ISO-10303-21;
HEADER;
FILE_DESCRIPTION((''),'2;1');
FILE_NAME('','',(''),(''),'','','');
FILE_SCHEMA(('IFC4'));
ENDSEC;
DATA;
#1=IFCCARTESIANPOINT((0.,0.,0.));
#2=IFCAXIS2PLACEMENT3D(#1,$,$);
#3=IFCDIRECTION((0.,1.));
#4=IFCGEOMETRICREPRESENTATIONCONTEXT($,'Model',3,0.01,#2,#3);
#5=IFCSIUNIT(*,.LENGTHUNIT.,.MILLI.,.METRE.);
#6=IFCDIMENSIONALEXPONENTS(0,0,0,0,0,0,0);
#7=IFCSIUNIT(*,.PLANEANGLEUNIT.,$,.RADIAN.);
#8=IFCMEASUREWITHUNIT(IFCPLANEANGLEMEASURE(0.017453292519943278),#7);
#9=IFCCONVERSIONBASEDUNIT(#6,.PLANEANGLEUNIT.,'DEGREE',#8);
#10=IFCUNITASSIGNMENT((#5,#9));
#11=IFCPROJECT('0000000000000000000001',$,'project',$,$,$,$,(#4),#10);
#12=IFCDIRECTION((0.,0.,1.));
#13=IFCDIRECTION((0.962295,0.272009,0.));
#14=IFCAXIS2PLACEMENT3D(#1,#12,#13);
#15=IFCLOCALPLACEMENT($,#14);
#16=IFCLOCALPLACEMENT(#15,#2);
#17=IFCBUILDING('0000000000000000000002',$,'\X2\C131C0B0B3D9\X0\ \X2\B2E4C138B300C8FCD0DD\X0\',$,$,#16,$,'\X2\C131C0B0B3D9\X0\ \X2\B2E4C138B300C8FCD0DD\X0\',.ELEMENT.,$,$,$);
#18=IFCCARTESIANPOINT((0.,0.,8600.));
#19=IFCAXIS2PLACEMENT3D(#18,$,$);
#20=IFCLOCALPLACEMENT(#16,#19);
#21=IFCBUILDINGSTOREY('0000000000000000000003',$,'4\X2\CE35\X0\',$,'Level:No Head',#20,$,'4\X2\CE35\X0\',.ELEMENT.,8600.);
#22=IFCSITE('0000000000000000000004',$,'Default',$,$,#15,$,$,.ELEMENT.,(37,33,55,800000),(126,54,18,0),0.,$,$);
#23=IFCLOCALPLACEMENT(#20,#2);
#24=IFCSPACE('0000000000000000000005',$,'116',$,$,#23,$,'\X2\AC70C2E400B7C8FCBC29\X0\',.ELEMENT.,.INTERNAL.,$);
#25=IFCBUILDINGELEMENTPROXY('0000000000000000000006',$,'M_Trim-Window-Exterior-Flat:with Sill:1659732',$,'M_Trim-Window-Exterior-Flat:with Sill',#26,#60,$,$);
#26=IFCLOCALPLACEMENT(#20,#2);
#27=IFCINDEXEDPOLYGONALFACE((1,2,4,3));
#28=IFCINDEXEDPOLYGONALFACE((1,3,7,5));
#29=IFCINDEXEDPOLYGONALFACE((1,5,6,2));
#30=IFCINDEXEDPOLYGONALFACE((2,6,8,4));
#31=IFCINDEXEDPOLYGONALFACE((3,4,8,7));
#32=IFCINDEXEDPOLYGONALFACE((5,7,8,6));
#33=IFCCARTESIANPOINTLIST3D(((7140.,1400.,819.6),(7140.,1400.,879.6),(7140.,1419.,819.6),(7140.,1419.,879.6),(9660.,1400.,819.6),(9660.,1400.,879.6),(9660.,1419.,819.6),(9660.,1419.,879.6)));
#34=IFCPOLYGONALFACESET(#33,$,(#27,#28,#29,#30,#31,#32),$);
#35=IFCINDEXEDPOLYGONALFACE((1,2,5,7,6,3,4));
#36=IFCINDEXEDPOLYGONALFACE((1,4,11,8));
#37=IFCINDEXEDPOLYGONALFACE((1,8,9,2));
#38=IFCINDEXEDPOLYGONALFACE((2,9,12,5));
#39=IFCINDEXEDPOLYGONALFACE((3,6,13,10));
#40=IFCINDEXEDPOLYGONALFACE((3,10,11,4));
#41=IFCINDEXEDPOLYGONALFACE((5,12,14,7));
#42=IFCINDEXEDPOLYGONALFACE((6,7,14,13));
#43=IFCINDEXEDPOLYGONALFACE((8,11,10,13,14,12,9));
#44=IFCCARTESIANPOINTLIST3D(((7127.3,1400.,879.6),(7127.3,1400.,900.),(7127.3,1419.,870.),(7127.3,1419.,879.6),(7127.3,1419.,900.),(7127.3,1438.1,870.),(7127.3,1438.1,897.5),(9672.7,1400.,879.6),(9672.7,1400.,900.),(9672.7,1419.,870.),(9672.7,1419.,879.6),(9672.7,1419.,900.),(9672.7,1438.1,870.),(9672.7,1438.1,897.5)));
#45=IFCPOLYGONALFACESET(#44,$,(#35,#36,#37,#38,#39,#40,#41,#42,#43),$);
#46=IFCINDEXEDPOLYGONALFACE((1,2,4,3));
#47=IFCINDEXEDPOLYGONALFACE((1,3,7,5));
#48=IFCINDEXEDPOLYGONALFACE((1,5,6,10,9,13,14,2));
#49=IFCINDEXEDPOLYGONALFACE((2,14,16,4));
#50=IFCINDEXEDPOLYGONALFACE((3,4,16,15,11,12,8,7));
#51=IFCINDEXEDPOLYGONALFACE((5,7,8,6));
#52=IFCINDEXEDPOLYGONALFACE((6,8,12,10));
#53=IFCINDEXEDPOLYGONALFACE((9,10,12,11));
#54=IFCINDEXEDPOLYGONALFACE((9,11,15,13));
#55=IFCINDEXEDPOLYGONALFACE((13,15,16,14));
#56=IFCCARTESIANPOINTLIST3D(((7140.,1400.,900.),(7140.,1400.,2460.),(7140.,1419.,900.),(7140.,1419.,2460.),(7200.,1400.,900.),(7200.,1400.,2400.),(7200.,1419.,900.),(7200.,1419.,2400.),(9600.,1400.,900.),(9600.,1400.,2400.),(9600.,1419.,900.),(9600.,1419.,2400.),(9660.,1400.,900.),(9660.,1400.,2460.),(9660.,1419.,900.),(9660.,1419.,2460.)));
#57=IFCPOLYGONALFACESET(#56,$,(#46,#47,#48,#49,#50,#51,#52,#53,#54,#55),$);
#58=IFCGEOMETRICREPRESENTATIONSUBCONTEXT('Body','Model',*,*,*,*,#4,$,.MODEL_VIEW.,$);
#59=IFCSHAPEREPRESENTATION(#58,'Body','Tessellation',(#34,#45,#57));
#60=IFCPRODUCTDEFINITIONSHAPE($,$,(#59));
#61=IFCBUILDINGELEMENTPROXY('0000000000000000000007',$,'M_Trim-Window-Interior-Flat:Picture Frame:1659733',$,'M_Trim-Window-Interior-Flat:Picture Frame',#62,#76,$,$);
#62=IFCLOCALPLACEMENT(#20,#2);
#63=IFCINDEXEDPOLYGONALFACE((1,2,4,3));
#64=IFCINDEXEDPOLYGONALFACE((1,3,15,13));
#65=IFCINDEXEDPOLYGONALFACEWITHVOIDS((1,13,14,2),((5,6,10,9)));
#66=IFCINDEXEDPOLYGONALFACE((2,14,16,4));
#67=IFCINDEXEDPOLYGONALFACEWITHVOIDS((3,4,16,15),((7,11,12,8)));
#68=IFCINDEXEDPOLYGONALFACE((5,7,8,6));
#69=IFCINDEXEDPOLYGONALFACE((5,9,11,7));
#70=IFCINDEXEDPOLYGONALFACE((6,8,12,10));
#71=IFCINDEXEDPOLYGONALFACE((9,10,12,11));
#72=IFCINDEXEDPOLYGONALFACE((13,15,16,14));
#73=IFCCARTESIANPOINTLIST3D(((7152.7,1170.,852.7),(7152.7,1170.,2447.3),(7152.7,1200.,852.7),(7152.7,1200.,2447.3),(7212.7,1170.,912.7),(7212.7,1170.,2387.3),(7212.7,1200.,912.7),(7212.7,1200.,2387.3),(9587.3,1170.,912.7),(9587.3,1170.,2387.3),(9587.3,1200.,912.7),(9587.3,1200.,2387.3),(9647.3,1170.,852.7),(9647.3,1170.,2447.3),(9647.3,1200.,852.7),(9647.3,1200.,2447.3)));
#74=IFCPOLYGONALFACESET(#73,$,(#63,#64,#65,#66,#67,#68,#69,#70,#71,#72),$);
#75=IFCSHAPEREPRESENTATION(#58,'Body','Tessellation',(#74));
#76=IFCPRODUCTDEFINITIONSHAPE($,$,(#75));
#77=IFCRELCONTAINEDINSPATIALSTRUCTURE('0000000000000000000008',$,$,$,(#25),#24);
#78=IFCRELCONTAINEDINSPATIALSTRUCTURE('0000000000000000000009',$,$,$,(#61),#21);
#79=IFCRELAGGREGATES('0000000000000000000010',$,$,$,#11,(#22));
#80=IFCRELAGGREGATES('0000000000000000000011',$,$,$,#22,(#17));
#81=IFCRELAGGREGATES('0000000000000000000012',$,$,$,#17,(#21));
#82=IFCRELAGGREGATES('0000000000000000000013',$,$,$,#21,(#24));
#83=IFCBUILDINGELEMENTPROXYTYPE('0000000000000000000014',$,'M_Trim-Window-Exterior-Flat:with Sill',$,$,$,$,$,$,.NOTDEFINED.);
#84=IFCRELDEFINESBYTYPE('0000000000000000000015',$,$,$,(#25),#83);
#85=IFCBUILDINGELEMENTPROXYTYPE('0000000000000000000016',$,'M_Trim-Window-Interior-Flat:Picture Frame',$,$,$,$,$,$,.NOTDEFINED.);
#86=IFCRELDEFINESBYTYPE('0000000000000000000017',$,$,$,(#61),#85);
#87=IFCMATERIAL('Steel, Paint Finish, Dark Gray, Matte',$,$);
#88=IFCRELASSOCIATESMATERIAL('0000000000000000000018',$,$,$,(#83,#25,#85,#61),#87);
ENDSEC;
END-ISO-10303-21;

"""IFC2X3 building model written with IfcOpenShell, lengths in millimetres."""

from ifc_helpers import new_model, entity, si_unit, converted_unit, direction, frame, frame_2d, origin, place, context, subcontext, project, spatial, polyline, rectangle, outline, extrude, source, transform, mapped, material, type_object, type_shapes, element, save


model = new_model("IFC2X3")

# Units and contexts
model_context = context("Model", 3, precision=0.01, world=origin(), true_north=direction((0.0, 1.0)))
body_context = subcontext(model_context, "Body", "Model", "MODEL_VIEW")
ifc_project = project(units=[si_unit("LENGTHUNIT", "METRE", prefix="MILLI"), converted_unit("PLANEANGLEUNIT", "DEGREE", entity("IfcPlaneAngleMeasure", 0.017453292519943278), si_unit("PLANEANGLEUNIT", "RADIAN"), dimensions=[0, 0, 0, 0, 0, 0, 0])], contexts=[model_context])

# Site, building, storey
site_placement = place(None, frame((0.0, 0.0, 0.0), z_axis=(0.0, 0.0, 1.0), x_axis=(0.962295, 0.272009, 0.0)))
site = spatial("IfcSite", under=ifc_project, at=site_placement, Name="Default", CompositionType="ELEMENT", RefLatitude=(37, 33, 55, 800000), RefLongitude=(126, 54, 18, 0), RefElevation=0.0)
building_placement = place(site_placement, origin())
building = spatial("IfcBuilding", under=site, at=building_placement, Name="성산동 다세대주택", LongName="성산동 다세대주택", CompositionType="ELEMENT")
storey_placement = place(building_placement, frame((0.0, 0.0, 8600.0)))
storey = spatial("IfcBuildingStorey", under=building, at=storey_placement, Name="4층", ObjectType="Level:No Head", LongName="4층", CompositionType="ELEMENT", Elevation=8600.0)

# Shared definitions
ifc_material_1 = material(Name="Steel, Paint Finish, Dark Gray, Matte")

# Shared definitions
space_1_placement = place(storey_placement, origin())
space_1 = spatial("IfcSpace", under=storey, at=space_1_placement, Name="116", LongName="거실·주방", CompositionType="ELEMENT", InteriorOrExteriorSpace="INTERNAL")

# Building element proxies
building_element_proxy_type_1 = type_object("IfcBuildingElementProxyType", Name="M_Trim-Window-Exterior-Flat:with Sill", PredefinedType="NOTDEFINED", material=ifc_material_1)
shared_shape_1 = source(origin(), body_context, "Body", "SweptSolid", [
    extrude(rectangle(XDim=2520.0, YDim=60.0, at=frame_2d((0.0, 0.0), x_axis=(1.0, 0.0))), frame((0.0, -1550.4, 0.0), z_axis=(0.0, 0.0, 1.0), x_axis=(-1.0, 0.0, 0.0)), (0.0, 0.0, 1.0), 19.0),
    extrude(outline(polyline([(-19.0, -15.2), (0.0, -15.2), (0.0, -5.7), (19.0, -5.7), (19.0, 14.8), (0.0, 14.8), (-19.0, 12.3), (-19.0, -15.2)])), frame((-1272.7, -1514.8, 19.0), z_axis=(1.0, 0.0, 0.0), x_axis=(0.0, 0.0, -1.0)), (0.0, 0.0, 1.0), 2545.4),
    extrude(outline(polyline([(-795.0, -1260.0), (765.0, -1260.0), (765.0, -1200.0), (-735.0, -1200.0), (-735.0, 1200.0), (765.0, 1200.0), (765.0, 1260.0), (-795.0, 1260.0), (-795.0, -1260.0)])), frame((0.0, -735.0, 0.0), z_axis=(0.0, 0.0, 1.0), x_axis=(0.0, -1.0, 0.0)), (0.0, 0.0, 1.0), 19.0),
])
type_shapes(building_element_proxy_type_1, [shared_shape_1])
proxy_1_placement = place(space_1_placement, frame((8400.0, 1400.0, 2400.0), z_axis=(0.0, 1.0, 0.0), x_axis=(-1.0, 0.0, 0.0)))
element("IfcBuildingElementProxy", 1, at=proxy_1_placement, inside=space_1, type_object=building_element_proxy_type_1, material=ifc_material_1, Name="M_Trim-Window-Exterior-Flat:with Sill:1659732", ObjectType="M_Trim-Window-Exterior-Flat:with Sill", context=body_context, shape_type="MappedRepresentation", body=[
    mapped(shared_shape_1, transform((0.0, 0.0, 0.0), scale=1.0)),
])
building_element_proxy_type_2 = type_object("IfcBuildingElementProxyType", Name="M_Trim-Window-Interior-Flat:Picture Frame", PredefinedType="NOTDEFINED", material=ifc_material_1)
shared_shape_2 = source(origin(), body_context, "Body", "SweptSolid", [
    extrude(outline(polyline([(-1247.3, -797.3), (1247.3, -797.3), (1247.3, 797.3), (-1247.3, 797.3), (-1247.3, -797.3)]), holes=[polyline([(-1187.3, -737.3), (-1187.3, 737.3), (1187.3, 737.3), (1187.3, -737.3), (-1187.3, -737.3)])]), frame((0.0, -750.0, 0.0), z_axis=(0.0, 0.0, 1.0), x_axis=(-1.0, 0.0, 0.0)), (0.0, 0.0, 1.0), 30.0),
])
type_shapes(building_element_proxy_type_2, [shared_shape_2])
proxy_2_placement = place(storey_placement, frame((8400.0, 1200.0, 2400.0), z_axis=(0.0, -1.0, 0.0), x_axis=(1.0, 0.0, 0.0)))
element("IfcBuildingElementProxy", 2, at=proxy_2_placement, inside=storey, type_object=building_element_proxy_type_2, material=ifc_material_1, Name="M_Trim-Window-Interior-Flat:Picture Frame:1659733", ObjectType="M_Trim-Window-Interior-Flat:Picture Frame", context=body_context, shape_type="MappedRepresentation", body=[
    mapped(shared_shape_2, transform((0.0, 0.0, 0.0), scale=1.0)),
])

save(model, "model.ifc")
